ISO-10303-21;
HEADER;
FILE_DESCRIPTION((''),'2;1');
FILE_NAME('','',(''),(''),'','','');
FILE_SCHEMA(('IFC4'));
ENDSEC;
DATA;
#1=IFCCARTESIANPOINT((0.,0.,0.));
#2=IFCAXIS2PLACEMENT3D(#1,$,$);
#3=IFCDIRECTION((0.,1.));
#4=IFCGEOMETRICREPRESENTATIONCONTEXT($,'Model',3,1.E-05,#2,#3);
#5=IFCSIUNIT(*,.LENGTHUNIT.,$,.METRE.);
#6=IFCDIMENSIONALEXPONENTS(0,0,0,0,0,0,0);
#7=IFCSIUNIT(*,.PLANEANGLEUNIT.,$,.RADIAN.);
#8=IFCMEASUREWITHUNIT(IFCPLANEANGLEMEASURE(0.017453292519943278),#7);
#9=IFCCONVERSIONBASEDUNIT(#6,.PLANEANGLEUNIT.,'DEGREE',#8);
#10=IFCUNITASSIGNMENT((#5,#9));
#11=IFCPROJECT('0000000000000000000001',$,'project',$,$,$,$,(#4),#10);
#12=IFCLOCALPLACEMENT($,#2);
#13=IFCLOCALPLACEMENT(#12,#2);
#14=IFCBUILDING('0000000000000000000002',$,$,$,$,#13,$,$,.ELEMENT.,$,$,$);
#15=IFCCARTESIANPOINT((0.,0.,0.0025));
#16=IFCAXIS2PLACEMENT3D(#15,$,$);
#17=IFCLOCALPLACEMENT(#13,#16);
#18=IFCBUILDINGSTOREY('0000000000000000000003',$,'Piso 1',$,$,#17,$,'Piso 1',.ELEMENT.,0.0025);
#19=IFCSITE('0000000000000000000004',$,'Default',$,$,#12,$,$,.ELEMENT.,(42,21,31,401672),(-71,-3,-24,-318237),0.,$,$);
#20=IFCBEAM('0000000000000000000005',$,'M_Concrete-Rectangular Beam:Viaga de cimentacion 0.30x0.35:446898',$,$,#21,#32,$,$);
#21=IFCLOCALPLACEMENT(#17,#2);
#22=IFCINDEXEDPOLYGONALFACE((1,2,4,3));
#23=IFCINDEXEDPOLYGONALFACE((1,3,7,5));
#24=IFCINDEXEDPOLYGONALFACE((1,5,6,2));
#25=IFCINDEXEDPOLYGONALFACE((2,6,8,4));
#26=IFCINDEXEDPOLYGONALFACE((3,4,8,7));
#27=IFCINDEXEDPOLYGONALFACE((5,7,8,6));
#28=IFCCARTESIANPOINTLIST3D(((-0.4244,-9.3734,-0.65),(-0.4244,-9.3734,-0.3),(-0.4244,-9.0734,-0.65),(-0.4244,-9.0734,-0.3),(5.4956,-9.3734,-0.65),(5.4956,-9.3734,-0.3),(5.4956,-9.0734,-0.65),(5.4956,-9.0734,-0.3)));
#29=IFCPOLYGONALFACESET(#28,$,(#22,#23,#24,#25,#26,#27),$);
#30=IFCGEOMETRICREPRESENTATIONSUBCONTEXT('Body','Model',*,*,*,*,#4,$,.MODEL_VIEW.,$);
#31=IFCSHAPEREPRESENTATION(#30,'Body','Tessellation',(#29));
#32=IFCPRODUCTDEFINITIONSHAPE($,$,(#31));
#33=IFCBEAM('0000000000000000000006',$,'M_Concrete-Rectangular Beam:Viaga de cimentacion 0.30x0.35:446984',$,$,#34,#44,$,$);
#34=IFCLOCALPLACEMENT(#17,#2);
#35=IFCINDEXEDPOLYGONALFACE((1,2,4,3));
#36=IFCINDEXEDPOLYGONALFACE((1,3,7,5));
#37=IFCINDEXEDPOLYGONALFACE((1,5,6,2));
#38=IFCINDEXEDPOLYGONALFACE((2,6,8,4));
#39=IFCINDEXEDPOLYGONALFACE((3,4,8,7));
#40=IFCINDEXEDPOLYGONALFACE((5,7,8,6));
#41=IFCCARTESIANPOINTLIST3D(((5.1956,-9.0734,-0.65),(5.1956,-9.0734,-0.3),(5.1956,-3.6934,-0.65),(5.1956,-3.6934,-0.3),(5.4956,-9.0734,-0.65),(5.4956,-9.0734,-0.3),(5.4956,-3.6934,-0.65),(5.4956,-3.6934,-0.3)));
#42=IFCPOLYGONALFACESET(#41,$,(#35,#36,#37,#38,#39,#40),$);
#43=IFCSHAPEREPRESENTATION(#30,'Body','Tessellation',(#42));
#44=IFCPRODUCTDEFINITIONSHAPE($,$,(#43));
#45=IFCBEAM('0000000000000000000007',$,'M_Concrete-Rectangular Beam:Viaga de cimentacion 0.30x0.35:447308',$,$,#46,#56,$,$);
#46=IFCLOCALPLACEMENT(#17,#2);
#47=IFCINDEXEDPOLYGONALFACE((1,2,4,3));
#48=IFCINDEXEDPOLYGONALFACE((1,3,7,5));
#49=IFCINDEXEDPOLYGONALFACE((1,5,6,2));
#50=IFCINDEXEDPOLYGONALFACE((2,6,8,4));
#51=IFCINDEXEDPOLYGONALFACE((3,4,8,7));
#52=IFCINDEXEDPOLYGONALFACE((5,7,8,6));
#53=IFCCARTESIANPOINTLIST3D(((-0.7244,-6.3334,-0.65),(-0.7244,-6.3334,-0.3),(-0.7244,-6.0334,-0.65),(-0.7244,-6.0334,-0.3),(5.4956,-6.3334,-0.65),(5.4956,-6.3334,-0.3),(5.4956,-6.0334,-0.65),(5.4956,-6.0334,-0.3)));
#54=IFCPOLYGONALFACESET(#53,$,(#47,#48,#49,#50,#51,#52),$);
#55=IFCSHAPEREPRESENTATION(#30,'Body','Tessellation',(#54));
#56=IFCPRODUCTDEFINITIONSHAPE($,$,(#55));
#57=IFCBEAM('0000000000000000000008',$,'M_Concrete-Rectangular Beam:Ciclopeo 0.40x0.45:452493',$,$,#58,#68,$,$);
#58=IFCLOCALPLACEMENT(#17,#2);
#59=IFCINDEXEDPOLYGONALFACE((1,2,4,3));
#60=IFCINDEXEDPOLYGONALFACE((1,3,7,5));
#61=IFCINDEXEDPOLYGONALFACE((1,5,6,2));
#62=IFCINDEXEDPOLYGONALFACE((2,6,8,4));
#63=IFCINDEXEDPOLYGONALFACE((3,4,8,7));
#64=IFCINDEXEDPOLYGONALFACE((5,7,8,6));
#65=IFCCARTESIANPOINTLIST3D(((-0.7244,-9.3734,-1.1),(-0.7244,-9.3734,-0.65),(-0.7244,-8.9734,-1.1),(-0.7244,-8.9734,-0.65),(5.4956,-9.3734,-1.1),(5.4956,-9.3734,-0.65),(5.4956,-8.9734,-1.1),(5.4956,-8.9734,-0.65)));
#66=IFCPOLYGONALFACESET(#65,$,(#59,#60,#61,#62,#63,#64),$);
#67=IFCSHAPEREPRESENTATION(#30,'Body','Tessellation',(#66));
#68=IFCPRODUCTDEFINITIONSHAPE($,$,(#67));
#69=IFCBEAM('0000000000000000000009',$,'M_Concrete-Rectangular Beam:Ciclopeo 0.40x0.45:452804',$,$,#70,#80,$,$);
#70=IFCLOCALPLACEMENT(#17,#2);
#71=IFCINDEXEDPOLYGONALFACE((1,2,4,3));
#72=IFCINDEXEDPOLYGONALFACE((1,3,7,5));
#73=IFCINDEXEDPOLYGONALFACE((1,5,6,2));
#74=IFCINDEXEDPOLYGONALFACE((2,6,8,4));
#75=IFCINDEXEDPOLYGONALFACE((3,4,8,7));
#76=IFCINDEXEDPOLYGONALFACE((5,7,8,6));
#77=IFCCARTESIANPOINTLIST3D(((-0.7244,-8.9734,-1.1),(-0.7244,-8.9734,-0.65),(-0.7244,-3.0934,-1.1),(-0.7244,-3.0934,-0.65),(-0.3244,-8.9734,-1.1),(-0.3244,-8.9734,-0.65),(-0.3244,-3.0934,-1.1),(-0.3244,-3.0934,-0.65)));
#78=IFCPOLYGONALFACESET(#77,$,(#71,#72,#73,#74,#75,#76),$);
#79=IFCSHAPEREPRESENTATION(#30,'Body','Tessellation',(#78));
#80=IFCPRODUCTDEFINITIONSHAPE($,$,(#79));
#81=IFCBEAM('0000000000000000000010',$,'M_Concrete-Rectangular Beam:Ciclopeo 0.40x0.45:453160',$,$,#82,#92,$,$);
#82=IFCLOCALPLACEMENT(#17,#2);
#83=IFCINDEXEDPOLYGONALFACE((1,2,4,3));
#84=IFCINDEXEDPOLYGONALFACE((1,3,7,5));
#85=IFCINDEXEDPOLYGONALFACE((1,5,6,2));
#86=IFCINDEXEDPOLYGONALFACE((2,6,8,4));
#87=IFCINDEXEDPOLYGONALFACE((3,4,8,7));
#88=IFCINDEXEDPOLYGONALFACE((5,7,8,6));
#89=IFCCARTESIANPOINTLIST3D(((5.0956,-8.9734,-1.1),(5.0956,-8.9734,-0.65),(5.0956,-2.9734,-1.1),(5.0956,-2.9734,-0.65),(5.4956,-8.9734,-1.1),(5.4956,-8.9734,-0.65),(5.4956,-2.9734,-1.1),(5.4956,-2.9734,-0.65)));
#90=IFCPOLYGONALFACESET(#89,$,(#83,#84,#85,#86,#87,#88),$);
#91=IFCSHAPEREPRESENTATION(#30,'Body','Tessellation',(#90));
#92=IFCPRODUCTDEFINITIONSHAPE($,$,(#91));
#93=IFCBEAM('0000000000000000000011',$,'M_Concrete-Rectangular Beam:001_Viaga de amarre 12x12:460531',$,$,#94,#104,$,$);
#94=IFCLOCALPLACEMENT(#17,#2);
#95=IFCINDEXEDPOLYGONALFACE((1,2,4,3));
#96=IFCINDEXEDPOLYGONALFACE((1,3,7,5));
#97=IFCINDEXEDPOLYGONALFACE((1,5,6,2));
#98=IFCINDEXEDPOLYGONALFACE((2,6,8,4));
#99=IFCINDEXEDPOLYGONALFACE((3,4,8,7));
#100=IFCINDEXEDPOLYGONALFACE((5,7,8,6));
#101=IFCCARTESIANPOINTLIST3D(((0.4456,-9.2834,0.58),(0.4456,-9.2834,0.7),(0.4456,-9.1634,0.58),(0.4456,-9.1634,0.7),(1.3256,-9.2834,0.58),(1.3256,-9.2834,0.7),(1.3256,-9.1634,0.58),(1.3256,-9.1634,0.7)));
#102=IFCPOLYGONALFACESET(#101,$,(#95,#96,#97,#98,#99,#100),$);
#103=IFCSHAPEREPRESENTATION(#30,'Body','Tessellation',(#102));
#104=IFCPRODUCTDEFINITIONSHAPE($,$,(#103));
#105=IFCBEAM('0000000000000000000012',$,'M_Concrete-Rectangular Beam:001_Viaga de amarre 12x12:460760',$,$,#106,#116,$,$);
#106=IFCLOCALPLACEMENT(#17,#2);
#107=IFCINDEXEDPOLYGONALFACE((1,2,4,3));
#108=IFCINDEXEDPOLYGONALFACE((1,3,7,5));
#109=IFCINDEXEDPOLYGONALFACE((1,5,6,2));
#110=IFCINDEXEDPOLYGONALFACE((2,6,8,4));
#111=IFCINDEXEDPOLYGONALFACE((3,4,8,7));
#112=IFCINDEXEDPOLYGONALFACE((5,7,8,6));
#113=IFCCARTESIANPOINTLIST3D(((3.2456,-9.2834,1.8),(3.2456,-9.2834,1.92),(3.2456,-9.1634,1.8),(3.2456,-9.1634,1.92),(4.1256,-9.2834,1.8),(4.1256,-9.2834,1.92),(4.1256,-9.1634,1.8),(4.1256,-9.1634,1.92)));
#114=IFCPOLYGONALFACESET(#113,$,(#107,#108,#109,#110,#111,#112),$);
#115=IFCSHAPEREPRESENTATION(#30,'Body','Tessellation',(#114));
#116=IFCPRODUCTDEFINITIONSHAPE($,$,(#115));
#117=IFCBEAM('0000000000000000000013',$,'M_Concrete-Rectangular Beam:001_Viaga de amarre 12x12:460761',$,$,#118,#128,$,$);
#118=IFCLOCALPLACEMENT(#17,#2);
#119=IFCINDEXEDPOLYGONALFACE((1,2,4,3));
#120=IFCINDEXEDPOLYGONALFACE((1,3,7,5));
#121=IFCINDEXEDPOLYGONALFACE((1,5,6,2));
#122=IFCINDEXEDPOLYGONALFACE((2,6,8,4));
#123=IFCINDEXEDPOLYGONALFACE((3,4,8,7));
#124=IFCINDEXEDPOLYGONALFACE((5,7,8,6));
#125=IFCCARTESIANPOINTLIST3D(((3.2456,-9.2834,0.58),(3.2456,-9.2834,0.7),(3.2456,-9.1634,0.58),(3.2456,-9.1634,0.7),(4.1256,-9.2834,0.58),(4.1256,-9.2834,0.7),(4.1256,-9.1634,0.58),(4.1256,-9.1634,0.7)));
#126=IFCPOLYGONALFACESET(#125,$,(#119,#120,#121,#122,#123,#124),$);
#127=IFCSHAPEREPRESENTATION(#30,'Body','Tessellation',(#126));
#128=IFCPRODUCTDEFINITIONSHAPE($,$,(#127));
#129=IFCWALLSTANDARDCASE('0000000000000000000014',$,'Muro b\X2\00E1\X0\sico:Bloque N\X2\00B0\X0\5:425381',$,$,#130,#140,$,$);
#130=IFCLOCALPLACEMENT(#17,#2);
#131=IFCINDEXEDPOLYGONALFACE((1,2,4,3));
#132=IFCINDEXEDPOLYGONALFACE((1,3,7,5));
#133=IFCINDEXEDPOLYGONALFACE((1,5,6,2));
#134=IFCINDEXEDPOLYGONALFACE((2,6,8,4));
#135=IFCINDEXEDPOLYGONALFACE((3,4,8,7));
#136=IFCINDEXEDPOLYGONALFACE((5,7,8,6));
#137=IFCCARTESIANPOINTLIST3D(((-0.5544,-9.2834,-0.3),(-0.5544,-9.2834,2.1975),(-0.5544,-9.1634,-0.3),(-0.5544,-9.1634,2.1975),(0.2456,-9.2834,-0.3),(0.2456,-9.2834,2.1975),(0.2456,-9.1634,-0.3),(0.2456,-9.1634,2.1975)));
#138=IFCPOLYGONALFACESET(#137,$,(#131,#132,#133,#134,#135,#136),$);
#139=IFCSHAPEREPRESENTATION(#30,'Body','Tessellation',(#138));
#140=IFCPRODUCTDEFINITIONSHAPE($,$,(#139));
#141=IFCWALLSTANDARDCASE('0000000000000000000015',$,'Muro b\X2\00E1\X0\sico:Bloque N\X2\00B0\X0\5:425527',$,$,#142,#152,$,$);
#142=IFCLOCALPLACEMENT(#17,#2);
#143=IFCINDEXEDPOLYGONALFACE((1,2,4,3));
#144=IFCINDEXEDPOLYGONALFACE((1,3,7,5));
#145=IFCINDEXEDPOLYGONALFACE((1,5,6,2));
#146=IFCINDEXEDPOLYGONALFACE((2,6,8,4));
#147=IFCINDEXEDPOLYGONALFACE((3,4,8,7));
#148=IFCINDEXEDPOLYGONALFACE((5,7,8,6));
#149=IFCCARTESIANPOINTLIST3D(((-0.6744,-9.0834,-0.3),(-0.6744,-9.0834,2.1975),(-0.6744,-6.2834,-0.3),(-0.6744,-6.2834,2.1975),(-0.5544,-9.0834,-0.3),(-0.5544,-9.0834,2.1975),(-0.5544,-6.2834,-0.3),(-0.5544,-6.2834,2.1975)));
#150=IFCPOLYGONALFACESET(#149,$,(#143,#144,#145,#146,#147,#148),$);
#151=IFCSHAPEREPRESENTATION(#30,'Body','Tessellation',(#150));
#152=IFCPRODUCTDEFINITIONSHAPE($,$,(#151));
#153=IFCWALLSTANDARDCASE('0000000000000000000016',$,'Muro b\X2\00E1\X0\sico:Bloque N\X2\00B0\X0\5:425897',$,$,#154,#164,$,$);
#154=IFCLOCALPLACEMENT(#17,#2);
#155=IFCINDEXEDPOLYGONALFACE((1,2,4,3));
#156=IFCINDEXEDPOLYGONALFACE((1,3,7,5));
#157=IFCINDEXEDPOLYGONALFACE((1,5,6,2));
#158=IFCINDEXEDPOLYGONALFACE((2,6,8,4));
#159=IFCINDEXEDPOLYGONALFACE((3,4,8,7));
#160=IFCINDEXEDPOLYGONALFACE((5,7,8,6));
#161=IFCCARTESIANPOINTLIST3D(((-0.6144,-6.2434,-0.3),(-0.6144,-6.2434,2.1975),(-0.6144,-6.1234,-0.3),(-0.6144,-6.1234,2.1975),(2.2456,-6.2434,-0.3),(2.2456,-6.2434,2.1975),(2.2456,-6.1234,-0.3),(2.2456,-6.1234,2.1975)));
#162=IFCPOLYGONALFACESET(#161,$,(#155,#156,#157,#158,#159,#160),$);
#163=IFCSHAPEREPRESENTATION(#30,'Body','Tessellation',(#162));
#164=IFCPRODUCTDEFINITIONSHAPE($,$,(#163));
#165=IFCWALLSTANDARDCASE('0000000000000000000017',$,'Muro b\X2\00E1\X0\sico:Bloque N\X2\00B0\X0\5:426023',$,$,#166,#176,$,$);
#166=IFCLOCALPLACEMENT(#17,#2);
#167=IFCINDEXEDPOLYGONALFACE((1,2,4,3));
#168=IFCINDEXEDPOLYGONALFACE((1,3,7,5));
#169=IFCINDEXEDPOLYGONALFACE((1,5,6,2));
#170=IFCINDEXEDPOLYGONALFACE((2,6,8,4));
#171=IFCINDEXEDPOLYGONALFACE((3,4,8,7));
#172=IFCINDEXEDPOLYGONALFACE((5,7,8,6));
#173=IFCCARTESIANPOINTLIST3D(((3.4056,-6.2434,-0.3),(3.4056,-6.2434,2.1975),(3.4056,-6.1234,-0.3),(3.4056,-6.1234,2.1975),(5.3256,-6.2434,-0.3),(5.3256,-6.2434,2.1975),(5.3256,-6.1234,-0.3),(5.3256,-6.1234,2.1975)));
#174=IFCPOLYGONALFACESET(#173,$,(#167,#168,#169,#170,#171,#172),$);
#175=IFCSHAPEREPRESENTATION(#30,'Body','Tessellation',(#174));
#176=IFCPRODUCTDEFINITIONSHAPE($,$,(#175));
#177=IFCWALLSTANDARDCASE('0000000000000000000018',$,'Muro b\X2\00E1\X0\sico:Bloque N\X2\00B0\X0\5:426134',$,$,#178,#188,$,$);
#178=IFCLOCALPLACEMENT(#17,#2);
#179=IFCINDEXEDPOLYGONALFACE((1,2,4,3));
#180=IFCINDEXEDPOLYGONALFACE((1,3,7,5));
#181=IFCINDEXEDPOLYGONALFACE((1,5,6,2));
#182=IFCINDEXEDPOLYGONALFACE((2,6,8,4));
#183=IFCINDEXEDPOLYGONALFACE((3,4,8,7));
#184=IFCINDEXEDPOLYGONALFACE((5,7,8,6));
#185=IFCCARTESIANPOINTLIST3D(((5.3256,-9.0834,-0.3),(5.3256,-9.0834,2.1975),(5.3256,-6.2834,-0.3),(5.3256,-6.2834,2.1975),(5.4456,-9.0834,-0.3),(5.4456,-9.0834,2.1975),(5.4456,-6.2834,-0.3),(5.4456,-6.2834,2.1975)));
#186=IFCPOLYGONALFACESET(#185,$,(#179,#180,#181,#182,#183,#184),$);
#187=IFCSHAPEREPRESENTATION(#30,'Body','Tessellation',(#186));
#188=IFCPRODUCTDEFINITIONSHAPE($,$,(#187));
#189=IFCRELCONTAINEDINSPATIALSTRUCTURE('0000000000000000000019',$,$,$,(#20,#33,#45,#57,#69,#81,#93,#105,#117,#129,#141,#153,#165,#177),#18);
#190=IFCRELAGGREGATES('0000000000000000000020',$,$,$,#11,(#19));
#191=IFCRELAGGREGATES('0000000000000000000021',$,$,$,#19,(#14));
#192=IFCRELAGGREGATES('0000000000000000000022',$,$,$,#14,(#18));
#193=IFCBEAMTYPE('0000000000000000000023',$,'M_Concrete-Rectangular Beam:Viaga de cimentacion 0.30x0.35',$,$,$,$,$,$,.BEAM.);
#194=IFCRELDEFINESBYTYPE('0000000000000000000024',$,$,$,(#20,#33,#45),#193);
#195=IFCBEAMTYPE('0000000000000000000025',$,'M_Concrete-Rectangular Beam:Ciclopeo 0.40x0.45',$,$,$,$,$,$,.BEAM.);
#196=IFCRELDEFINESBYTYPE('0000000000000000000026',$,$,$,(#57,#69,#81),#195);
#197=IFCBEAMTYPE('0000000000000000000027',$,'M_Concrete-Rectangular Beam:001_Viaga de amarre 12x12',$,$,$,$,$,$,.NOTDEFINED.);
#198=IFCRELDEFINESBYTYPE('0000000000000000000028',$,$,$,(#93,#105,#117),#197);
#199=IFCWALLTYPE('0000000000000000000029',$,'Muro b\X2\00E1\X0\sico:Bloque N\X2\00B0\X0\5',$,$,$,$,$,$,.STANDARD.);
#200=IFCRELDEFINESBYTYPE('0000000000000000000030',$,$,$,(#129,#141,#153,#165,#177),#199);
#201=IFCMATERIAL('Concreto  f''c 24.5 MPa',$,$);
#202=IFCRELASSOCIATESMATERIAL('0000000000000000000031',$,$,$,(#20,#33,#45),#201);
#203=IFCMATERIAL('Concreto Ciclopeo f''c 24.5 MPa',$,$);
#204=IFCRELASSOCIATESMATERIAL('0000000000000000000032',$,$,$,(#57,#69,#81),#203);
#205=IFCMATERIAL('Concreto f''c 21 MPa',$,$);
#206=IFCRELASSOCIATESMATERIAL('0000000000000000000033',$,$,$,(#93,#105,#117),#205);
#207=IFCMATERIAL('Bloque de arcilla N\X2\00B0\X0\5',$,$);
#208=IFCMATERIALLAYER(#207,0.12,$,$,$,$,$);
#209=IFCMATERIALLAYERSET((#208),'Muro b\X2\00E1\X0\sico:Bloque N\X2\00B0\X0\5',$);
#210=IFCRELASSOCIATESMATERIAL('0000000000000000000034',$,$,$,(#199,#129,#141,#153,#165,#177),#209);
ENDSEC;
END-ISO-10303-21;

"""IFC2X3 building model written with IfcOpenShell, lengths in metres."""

from ifc_helpers import new_model, entity, si_unit, converted_unit, direction, frame, frame_2d, origin, place, context, subcontext, project, spatial, rectangle, extrude, material, layer, layer_set, layer_usage, type_object, element, save


model = new_model("IFC2X3")

# Units and contexts
model_context = context("Model", 3, precision=1e-05, world=origin(), true_north=direction((0.0, 1.0)))
body_context = subcontext(model_context, "Body", "Model", "MODEL_VIEW")
ifc_project = project(units=[si_unit("LENGTHUNIT", "METRE"), converted_unit("PLANEANGLEUNIT", "DEGREE", entity("IfcPlaneAngleMeasure", 0.017453292519943278), si_unit("PLANEANGLEUNIT", "RADIAN"), dimensions=[0, 0, 0, 0, 0, 0, 0])], contexts=[model_context])

# Site, building, storey
site_placement = place(None, origin())
site = spatial("IfcSite", under=ifc_project, at=site_placement, Name="Default", CompositionType="ELEMENT", RefLatitude=(42, 21, 31, 401672), RefLongitude=(-71, -3, -24, -318237), RefElevation=0.0)
building_placement = place(site_placement, origin())
building = spatial("IfcBuilding", under=site, at=building_placement, CompositionType="ELEMENT")
storey_placement = place(building_placement, frame((0.0, 0.0, 0.0025)))
storey = spatial("IfcBuildingStorey", under=building, at=storey_placement, Name="Piso 1", LongName="Piso 1", CompositionType="ELEMENT", Elevation=0.0025)

# Beams
ifc_material_1 = material(Name="Concreto  f'c 24.5 MPa")
beam_type_1 = type_object("IfcBeamType", Name="M_Concrete-Rectangular Beam:Viaga de cimentacion 0.30x0.35", PredefinedType="BEAM")
beam_1_placement = place(storey_placement, frame((5.3456, -9.2234, -0.3), z_axis=(0.0, 0.0, 1.0), x_axis=(-1.0, 0.0, 0.0)))
element("IfcBeam", 1, at=beam_1_placement, inside=storey, type_object=beam_type_1, material=ifc_material_1, Name="M_Concrete-Rectangular Beam:Viaga de cimentacion 0.30x0.35:446898", context=body_context, shape_type="SweptSolid", body=[
    extrude(rectangle(XDim=0.35, YDim=0.3, at=frame_2d((0.0, 0.0), x_axis=(1.0, 0.0))), frame((-0.15, 0.0, -0.175), z_axis=(1.0, 0.0, 0.0), x_axis=(0.0, 0.0, -1.0)), (0.0, 0.0, 1.0), 5.92),
])
beam_2_placement = place(storey_placement, frame((5.3456, -9.2234, -0.3), z_axis=(0.0, 0.0, 1.0), x_axis=(0.0, 1.0, 0.0)))
element("IfcBeam", 2, at=beam_2_placement, inside=storey, type_object=beam_type_1, material=ifc_material_1, Name="M_Concrete-Rectangular Beam:Viaga de cimentacion 0.30x0.35:446984", context=body_context, shape_type="SweptSolid", body=[
    extrude(rectangle(XDim=0.35, YDim=0.3, at=frame_2d((0.0, 0.0), x_axis=(1.0, 0.0))), frame((0.15, 0.0, -0.175), z_axis=(1.0, 0.0, 0.0), x_axis=(0.0, 0.0, -1.0)), (0.0, 0.0, 1.0), 5.38),
])
beam_3_placement = place(storey_placement, frame((-0.5744, -6.1834, -0.3)))
element("IfcBeam", 3, at=beam_3_placement, inside=storey, type_object=beam_type_1, material=ifc_material_1, Name="M_Concrete-Rectangular Beam:Viaga de cimentacion 0.30x0.35:447308", context=body_context, shape_type="SweptSolid", body=[
    extrude(rectangle(XDim=0.35, YDim=0.3, at=frame_2d((0.0, 0.0), x_axis=(1.0, 0.0))), frame((-0.15, 0.0, -0.175), z_axis=(1.0, 0.0, 0.0), x_axis=(0.0, 0.0, -1.0)), (0.0, 0.0, 1.0), 6.22),
])
ifc_material_2 = material(Name="Concreto Ciclopeo f'c 24.5 MPa")
beam_type_2 = type_object("IfcBeamType", Name="M_Concrete-Rectangular Beam:Ciclopeo 0.40x0.45", PredefinedType="BEAM")
beam_4_placement = place(storey_placement, frame((-0.5244, -9.1734, -0.65)))
element("IfcBeam", 4, at=beam_4_placement, inside=storey, type_object=beam_type_2, material=ifc_material_2, Name="M_Concrete-Rectangular Beam:Ciclopeo 0.40x0.45:452493", context=body_context, shape_type="SweptSolid", body=[
    extrude(rectangle(XDim=0.45, YDim=0.4, at=frame_2d((0.0, 0.0), x_axis=(1.0, 0.0))), frame((-0.2, 0.0, -0.225), z_axis=(1.0, 0.0, 0.0), x_axis=(0.0, 0.0, -1.0)), (0.0, 0.0, 1.0), 6.22),
])
beam_5_placement = place(storey_placement, frame((-0.5244, -9.1734, -0.65), z_axis=(0.0, 0.0, 1.0), x_axis=(0.0, 1.0, 0.0)))
element("IfcBeam", 5, at=beam_5_placement, inside=storey, type_object=beam_type_2, material=ifc_material_2, Name="M_Concrete-Rectangular Beam:Ciclopeo 0.40x0.45:452804", context=body_context, shape_type="SweptSolid", body=[
    extrude(rectangle(XDim=0.45, YDim=0.4, at=frame_2d((0.0, 0.0), x_axis=(1.0, 0.0))), frame((0.2, 0.0, -0.225), z_axis=(1.0, 0.0, 0.0), x_axis=(0.0, 0.0, -1.0)), (0.0, 0.0, 1.0), 5.88),
])
beam_6_placement = place(storey_placement, frame((5.2956, -9.1734, -0.65), z_axis=(0.0, 0.0, 1.0), x_axis=(0.0, 1.0, 0.0)))
element("IfcBeam", 6, at=beam_6_placement, inside=storey, type_object=beam_type_2, material=ifc_material_2, Name="M_Concrete-Rectangular Beam:Ciclopeo 0.40x0.45:453160", context=body_context, shape_type="SweptSolid", body=[
    extrude(rectangle(XDim=0.45, YDim=0.4, at=frame_2d((0.0, 0.0), x_axis=(1.0, 0.0))), frame((0.2, 0.0, -0.225), z_axis=(1.0, 0.0, 0.0), x_axis=(0.0, 0.0, -1.0)), (0.0, 0.0, 1.0), 6.0),
])
ifc_material_3 = material(Name="Concreto f'c 21 MPa")
beam_type_3 = type_object("IfcBeamType", Name="M_Concrete-Rectangular Beam:001_Viaga de amarre 12x12", PredefinedType="NOTDEFINED")
beam_7_placement = place(storey_placement, frame((0.3456, -9.2234, 0.7)))
element("IfcBeam", 7, at=beam_7_placement, inside=storey, type_object=beam_type_3, material=ifc_material_3, Name="M_Concrete-Rectangular Beam:001_Viaga de amarre 12x12:460531", context=body_context, shape_type="SweptSolid", body=[
    extrude(rectangle(XDim=0.12, YDim=0.12, at=frame_2d((0.0, 0.0), x_axis=(1.0, 0.0))), frame((0.1, 0.0, -0.06), z_axis=(1.0, 0.0, 0.0), x_axis=(0.0, 0.0, -1.0)), (0.0, 0.0, 1.0), 0.88),
])
beam_8_placement = place(storey_placement, frame((3.1456, -9.2234, 1.92)))
element("IfcBeam", 8, at=beam_8_placement, inside=storey, type_object=beam_type_3, material=ifc_material_3, Name="M_Concrete-Rectangular Beam:001_Viaga de amarre 12x12:460760", context=body_context, shape_type="SweptSolid", body=[
    extrude(rectangle(XDim=0.12, YDim=0.12, at=frame_2d((0.0, 0.0), x_axis=(1.0, 0.0))), frame((0.1, 0.0, -0.06), z_axis=(1.0, 0.0, 0.0), x_axis=(0.0, 0.0, -1.0)), (0.0, 0.0, 1.0), 0.88),
])
beam_9_placement = place(storey_placement, frame((3.1456, -9.2234, 0.7)))
element("IfcBeam", 9, at=beam_9_placement, inside=storey, type_object=beam_type_3, material=ifc_material_3, Name="M_Concrete-Rectangular Beam:001_Viaga de amarre 12x12:460761", context=body_context, shape_type="SweptSolid", body=[
    extrude(rectangle(XDim=0.12, YDim=0.12, at=frame_2d((0.0, 0.0), x_axis=(1.0, 0.0))), frame((0.1, 0.0, -0.06), z_axis=(1.0, 0.0, 0.0), x_axis=(0.0, 0.0, -1.0)), (0.0, 0.0, 1.0), 0.88),
])

# Walls
ifc_material_4 = material(Name="Bloque de arcilla N°5")
ifc_layer = layer(ifc_material_4, 0.12)
ifc_layer_set = layer_set([ifc_layer], Name="Muro básico:Bloque N°5")
ifc_layer_usage_1 = layer_usage(ifc_layer_set, "AXIS2", "NEGATIVE", 0.06)
wall_type = type_object("IfcWallType", Name="Muro básico:Bloque N°5", PredefinedType="STANDARD", material=ifc_layer_set)
wall_1_placement = place(storey_placement, frame((-0.5544, -9.2234, -0.3)))
element("IfcWallStandardCase", 10, at=wall_1_placement, inside=storey, type_object=wall_type, material=ifc_layer_usage_1, Name="Muro básico:Bloque N°5:425381", context=body_context, shape_type="SweptSolid", body=[
    extrude(rectangle(XDim=0.8, YDim=0.12, at=frame_2d((0.4, 0.0), x_axis=(-1.0, 0.0))), origin(), (0.0, 0.0, 1.0), 2.4975),
])
ifc_layer_usage_2 = layer_usage(ifc_layer_set, "AXIS2", "NEGATIVE", 0.06)
wall_2_placement = place(storey_placement, frame((-0.6144, -9.0834, -0.3), z_axis=(0.0, 0.0, 1.0), x_axis=(0.0, 1.0, 0.0)))
element("IfcWallStandardCase", 11, at=wall_2_placement, inside=storey, type_object=wall_type, material=ifc_layer_usage_2, Name="Muro básico:Bloque N°5:425527", context=body_context, shape_type="SweptSolid", body=[
    extrude(rectangle(XDim=2.8, YDim=0.12, at=frame_2d((1.4, 0.0), x_axis=(-1.0, 0.0))), origin(), (0.0, 0.0, 1.0), 2.4975),
])
ifc_layer_usage_3 = layer_usage(ifc_layer_set, "AXIS2", "NEGATIVE", 0.06)
wall_3_placement = place(storey_placement, frame((-0.6144, -6.1834, -0.3)))
element("IfcWallStandardCase", 12, at=wall_3_placement, inside=storey, type_object=wall_type, material=ifc_layer_usage_3, Name="Muro básico:Bloque N°5:425897", context=body_context, shape_type="SweptSolid", body=[
    extrude(rectangle(XDim=2.86, YDim=0.12, at=frame_2d((1.43, 0.0), x_axis=(-1.0, 0.0))), origin(), (0.0, 0.0, 1.0), 2.4975),
])
ifc_layer_usage_4 = layer_usage(ifc_layer_set, "AXIS2", "NEGATIVE", 0.06)
wall_4_placement = place(storey_placement, frame((3.4056, -6.1834, -0.3)))
element("IfcWallStandardCase", 13, at=wall_4_placement, inside=storey, type_object=wall_type, material=ifc_layer_usage_4, Name="Muro básico:Bloque N°5:426023", context=body_context, shape_type="SweptSolid", body=[
    extrude(rectangle(XDim=1.92, YDim=0.12, at=frame_2d((0.96, 0.0), x_axis=(-1.0, 0.0))), origin(), (0.0, 0.0, 1.0), 2.4975),
])
ifc_layer_usage_5 = layer_usage(ifc_layer_set, "AXIS2", "NEGATIVE", 0.06)
wall_5_placement = place(storey_placement, frame((5.3856, -9.0834, -0.3), z_axis=(0.0, 0.0, 1.0), x_axis=(0.0, 1.0, 0.0)))
element("IfcWallStandardCase", 14, at=wall_5_placement, inside=storey, type_object=wall_type, material=ifc_layer_usage_5, Name="Muro básico:Bloque N°5:426134", context=body_context, shape_type="SweptSolid", body=[
    extrude(rectangle(XDim=2.8, YDim=0.12, at=frame_2d((1.4, 0.0), x_axis=(-1.0, 0.0))), origin(), (0.0, 0.0, 1.0), 2.4975),
])

save(model, "model.ifc")
